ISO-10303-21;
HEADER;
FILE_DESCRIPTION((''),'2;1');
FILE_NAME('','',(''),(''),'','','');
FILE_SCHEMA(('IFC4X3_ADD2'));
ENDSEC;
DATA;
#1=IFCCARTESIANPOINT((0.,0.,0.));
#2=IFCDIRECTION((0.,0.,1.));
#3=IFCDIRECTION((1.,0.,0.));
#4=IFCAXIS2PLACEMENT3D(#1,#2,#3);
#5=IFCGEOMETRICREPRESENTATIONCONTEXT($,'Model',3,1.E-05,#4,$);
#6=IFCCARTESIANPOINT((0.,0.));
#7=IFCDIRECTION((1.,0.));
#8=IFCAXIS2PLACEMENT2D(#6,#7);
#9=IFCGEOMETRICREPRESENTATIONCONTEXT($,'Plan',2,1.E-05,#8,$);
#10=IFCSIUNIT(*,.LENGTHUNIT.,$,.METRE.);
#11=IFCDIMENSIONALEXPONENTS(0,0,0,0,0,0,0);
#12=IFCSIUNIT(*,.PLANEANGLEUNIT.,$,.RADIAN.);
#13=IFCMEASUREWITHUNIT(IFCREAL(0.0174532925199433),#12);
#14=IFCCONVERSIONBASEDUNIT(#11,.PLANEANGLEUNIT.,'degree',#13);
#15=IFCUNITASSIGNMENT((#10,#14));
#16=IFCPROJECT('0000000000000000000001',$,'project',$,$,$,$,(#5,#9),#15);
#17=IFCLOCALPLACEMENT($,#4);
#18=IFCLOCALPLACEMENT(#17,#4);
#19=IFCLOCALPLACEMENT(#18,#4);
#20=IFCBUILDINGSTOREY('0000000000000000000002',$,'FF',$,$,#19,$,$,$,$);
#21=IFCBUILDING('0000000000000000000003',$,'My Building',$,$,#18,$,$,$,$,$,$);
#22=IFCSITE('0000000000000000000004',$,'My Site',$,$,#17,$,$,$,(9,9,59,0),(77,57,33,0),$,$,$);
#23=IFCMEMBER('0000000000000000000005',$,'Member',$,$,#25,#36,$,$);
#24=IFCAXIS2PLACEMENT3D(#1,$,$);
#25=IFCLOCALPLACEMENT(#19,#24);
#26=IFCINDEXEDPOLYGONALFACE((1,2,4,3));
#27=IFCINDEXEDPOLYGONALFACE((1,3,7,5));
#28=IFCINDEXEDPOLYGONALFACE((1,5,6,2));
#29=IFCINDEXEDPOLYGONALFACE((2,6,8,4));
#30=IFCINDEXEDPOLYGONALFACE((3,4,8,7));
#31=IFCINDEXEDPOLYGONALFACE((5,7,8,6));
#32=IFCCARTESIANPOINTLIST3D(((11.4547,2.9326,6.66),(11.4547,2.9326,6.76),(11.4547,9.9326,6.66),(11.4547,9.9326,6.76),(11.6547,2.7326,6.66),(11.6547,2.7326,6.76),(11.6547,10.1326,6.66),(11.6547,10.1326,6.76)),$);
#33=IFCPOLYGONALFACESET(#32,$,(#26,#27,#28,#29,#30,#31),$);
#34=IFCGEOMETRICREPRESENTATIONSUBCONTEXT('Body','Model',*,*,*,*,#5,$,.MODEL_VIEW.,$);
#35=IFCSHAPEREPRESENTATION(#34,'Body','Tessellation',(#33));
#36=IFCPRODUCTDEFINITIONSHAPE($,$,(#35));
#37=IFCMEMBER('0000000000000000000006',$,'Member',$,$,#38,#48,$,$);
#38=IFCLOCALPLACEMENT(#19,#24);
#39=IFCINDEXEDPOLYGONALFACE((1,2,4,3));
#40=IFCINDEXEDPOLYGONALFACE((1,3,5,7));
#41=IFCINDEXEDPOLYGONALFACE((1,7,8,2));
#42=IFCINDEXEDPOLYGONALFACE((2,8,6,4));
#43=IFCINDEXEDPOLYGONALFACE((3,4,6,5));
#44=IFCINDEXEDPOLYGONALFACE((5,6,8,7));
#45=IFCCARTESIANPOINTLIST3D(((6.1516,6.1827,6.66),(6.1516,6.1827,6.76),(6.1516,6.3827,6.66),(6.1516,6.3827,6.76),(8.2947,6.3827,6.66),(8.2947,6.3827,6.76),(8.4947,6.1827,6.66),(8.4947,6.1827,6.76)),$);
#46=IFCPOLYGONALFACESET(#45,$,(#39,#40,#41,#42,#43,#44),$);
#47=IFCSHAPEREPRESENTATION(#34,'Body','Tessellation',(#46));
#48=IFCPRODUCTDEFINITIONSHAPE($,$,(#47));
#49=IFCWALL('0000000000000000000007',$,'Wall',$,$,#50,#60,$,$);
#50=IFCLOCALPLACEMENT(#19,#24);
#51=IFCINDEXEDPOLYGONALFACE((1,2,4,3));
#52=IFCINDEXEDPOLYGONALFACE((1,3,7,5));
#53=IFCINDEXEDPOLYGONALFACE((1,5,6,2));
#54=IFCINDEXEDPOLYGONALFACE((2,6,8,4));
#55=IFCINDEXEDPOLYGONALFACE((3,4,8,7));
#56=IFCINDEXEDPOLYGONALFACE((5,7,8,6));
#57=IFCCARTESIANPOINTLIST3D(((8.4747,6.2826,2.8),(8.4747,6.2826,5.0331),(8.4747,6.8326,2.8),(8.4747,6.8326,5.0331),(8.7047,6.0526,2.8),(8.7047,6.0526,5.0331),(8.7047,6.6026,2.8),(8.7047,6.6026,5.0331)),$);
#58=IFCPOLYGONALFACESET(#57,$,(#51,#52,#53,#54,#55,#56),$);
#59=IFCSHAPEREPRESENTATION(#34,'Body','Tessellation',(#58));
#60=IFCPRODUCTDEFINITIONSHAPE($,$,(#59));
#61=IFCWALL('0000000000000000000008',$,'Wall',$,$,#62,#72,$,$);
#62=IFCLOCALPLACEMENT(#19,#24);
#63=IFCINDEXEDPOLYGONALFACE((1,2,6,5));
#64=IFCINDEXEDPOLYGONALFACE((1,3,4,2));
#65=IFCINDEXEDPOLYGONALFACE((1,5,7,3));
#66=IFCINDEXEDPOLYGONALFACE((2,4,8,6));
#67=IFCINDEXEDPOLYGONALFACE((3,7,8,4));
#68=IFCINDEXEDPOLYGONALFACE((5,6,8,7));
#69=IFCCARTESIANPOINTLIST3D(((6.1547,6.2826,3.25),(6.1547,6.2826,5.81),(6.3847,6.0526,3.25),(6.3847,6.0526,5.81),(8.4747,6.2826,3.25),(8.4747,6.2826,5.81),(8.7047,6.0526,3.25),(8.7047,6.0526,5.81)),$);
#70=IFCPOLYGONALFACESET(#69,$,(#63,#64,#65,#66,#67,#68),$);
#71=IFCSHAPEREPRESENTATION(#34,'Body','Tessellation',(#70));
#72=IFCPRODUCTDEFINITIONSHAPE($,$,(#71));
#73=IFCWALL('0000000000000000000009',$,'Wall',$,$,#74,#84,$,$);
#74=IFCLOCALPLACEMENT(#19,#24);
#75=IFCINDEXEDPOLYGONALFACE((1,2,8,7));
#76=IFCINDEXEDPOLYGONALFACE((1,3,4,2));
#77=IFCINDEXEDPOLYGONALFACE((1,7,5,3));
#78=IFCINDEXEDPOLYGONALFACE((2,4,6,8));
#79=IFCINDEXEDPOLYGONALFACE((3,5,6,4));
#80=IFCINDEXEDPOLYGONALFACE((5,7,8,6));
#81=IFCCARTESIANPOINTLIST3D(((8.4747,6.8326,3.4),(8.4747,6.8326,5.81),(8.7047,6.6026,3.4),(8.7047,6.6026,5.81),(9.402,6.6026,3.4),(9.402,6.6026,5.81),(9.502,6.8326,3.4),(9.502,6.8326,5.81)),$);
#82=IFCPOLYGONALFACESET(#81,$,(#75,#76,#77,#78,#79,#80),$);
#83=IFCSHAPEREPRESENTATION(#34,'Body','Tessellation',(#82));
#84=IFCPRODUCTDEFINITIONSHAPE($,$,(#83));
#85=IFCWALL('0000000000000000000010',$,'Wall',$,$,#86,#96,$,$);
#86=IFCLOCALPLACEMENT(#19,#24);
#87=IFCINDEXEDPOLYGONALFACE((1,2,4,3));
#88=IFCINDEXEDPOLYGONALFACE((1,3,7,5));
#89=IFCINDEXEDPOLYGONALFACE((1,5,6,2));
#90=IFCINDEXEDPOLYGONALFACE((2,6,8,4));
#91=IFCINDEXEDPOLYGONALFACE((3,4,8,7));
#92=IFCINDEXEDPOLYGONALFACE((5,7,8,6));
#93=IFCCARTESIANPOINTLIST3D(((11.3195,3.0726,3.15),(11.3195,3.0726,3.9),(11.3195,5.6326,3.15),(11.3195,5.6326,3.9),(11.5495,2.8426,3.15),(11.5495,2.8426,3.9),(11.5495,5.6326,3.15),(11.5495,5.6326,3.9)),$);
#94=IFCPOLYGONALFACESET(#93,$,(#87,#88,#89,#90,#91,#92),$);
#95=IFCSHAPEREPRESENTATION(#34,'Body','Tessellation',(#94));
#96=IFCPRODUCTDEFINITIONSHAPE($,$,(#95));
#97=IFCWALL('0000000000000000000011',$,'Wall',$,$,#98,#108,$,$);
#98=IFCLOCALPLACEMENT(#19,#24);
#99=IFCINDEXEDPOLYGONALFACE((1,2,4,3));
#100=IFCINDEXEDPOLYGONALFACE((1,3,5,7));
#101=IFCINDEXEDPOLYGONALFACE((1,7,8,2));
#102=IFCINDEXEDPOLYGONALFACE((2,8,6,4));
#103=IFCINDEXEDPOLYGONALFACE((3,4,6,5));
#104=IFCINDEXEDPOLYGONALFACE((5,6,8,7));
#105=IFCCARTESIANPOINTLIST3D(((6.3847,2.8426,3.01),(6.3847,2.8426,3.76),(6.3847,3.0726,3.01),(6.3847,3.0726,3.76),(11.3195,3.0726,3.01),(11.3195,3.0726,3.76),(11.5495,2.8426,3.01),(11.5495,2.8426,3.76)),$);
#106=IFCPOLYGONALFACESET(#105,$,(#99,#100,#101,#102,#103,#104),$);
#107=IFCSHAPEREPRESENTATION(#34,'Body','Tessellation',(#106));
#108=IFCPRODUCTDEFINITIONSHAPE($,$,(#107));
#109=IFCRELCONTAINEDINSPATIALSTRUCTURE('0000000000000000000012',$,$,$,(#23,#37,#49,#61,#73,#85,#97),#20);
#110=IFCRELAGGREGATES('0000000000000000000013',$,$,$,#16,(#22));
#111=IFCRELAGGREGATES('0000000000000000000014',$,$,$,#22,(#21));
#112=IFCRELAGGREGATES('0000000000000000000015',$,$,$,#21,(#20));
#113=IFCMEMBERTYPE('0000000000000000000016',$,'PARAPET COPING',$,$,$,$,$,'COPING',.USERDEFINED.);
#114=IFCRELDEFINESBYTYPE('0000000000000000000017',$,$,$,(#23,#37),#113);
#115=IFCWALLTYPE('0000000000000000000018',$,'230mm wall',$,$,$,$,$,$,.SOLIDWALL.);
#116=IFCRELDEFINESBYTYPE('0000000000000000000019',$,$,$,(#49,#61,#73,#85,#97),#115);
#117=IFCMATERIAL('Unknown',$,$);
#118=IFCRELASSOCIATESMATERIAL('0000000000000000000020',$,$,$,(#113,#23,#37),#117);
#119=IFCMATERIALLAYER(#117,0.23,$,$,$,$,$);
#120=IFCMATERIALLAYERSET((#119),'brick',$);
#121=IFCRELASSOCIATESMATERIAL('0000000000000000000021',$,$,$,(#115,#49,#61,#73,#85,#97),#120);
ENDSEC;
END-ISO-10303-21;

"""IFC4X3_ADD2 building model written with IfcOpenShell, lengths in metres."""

from ifc_helpers import new_model, entity, si_unit, converted_unit, frame, origin_with_axes, origin_2d_with_axis, place, context, subcontext, project, spatial, line, indexed_curve, rectangle, outline, extrude, clip, halfspace, material, layer, layer_set, layer_usage, material_profile, profile_set, profile_usage, type_object, element, save


model = new_model("IFC4X3_ADD2")

# Units and contexts
model_context = context("Model", 3, precision=1e-05, world=origin_with_axes())
plan_context = context("Plan", 2, precision=1e-05, world=origin_2d_with_axis())
body_context_1 = subcontext(model_context, "Body", "Model", "MODEL_VIEW")
ifc_project = project(units=[si_unit("LENGTHUNIT", "METRE"), converted_unit("PLANEANGLEUNIT", "degree", entity("IfcReal", 0.0174532925199433), si_unit("PLANEANGLEUNIT", "RADIAN"), dimensions=[0, 0, 0, 0, 0, 0, 0])], contexts=[model_context, plan_context])

# Site, building, storey
site_placement = place(None, origin_with_axes())
site = spatial("IfcSite", under=ifc_project, at=site_placement, Name="My Site", RefLatitude=(9, 9, 59, 0), RefLongitude=(77, 57, 33, 0))
building_placement = place(site_placement, origin_with_axes())
building = spatial("IfcBuilding", under=site, at=building_placement, Name="My Building")
storey_placement = place(building_placement, origin_with_axes())
storey = spatial("IfcBuildingStorey", under=building, at=storey_placement, Name="FF")

# Members
ifc_material = material(Name="Unknown")
ifc_material_profile = material_profile(ifc_material, rectangle(XDim=0.2, YDim=0.1))
ifc_profile_set = profile_set([ifc_material_profile])
ifc_profile_usage_1 = profile_usage(ifc_profile_set, cardinal=5)
member_type = type_object("IfcMemberType", Name="PARAPET COPING", ElementType="COPING", PredefinedType="USERDEFINED", material=ifc_profile_set)
member_1_placement = place(storey_placement, frame((11.5547, 2.7326, 6.71), z_axis=(0.0, 1.0, 0.0), x_axis=(-1.0, 0.0, 0.0)))
element("IfcMember", 1, at=member_1_placement, inside=storey, type_object=member_type, material=ifc_profile_usage_1, Name="Member", context=body_context_1, shape_type="Clipping", body=[
    clip(clip(extrude(rectangle(XDim=0.2, YDim=0.1), origin_with_axes(), (0.0, 0.0, 1.0), 7.4), halfspace(frame((-0.1, -6.66, 7.4), z_axis=(0.707107, 0.0, 0.707107), x_axis=(0.0, -1.0, 0.0)), False)), halfspace(frame((-0.1, -6.66, 0.0), z_axis=(0.707106, 0.0, -0.707108), x_axis=(0.0, -1.0, 0.0)), False)),
])
ifc_profile_usage_2 = profile_usage(ifc_profile_set, cardinal=5)
member_2_placement = place(storey_placement, frame((8.4947, 6.2827, 6.71), z_axis=(-1.0, 0.0, 0.0), x_axis=(0.0, -1.0, 0.0)))
element("IfcMember", 2, at=member_2_placement, inside=storey, type_object=member_type, material=ifc_profile_usage_2, Name="Member", context=body_context_1, shape_type="Clipping", body=[
    clip(extrude(rectangle(XDim=0.2, YDim=0.1), origin_with_axes(), (0.0, 0.0, 1.0), 2.3431), halfspace(frame((0.1, -6.66, 0.0), z_axis=(-0.707108, 0.0, -0.707105), x_axis=(0.0, 1.0, 0.0)), False)),
])

# Shared definitions
ifc_layer_1 = layer(ifc_material, 0.23)
ifc_layer_set_1 = layer_set([ifc_layer_1], Name="brick")
wall_type_1 = type_object("IfcWallType", Name="230mm wall", PredefinedType="SOLIDWALL", material=ifc_layer_set_1)

# Walls
ifc_layer_usage_1 = layer_usage(ifc_layer_set_1, "AXIS2", "POSITIVE", 0.0)
wall_1_placement = place(storey_placement, frame((8.7047, 6.2826, 2.8), z_axis=(0.0, 0.0, 1.0), x_axis=(0.0, 1.0, 0.0)))
element("IfcWall", 3, at=wall_1_placement, inside=storey, type_object=wall_type_1, material=ifc_layer_usage_1, Name="Wall", context=body_context_1, shape_type="SweptSolid", body=[
    extrude(outline(indexed_curve([(-0.23, 0.0), (0.0, 0.23), (0.55, 0.23), (0.32, 0.0)], segments=[line(1, 2, 3, 4, 1)])), origin_with_axes(), (0.0, 0.0, 1.0), 2.2331),
])
ifc_layer_usage_2 = layer_usage(ifc_layer_set_1, "AXIS2", "POSITIVE", 0.0)
wall_2_placement = place(storey_placement, frame((8.7047, 6.2826, 3.25), z_axis=(0.0, 0.0, 1.0), x_axis=(-1.0, 0.0, 0.0)))
element("IfcWall", 4, at=wall_2_placement, inside=storey, type_object=wall_type_1, material=ifc_layer_usage_2, Name="Wall", context=body_context_1, shape_type="SweptSolid", body=[
    extrude(outline(indexed_curve([(0.23, 0.0), (0.0, 0.23), (2.32, 0.23), (2.55, 0.0)], segments=[line(1, 2, 3, 4, 1)])), origin_with_axes(), (0.0, 0.0, 1.0), 2.56),
])
ifc_layer_usage_3 = layer_usage(ifc_layer_set_1, "AXIS2", "POSITIVE", 0.0)
wall_3_placement = place(storey_placement, frame((9.502, 6.8326, 3.4), z_axis=(0.0, 0.0, 1.0), x_axis=(-1.0, 0.0, 0.0)))
element("IfcWall", 5, at=wall_3_placement, inside=storey, type_object=wall_type_1, material=ifc_layer_usage_3, Name="Wall", context=body_context_1, shape_type="SweptSolid", body=[
    extrude(outline(indexed_curve([(0.0, 0.0), (0.1, 0.23), (0.7974, 0.23), (1.0274, 0.0)], segments=[line(1, 2, 3, 4, 1)])), origin_with_axes(), (0.0, 0.0, 1.0), 2.41),
])
ifc_layer_usage_4 = layer_usage(ifc_layer_set_1, "AXIS2", "POSITIVE", 0.0)
wall_4_placement = place(storey_placement, frame((11.5495, 2.8426, 3.15), z_axis=(0.0, 0.0, 1.0), x_axis=(0.0, 1.0, 0.0)))
element("IfcWall", 6, at=wall_4_placement, inside=storey, type_object=wall_type_1, material=ifc_layer_usage_4, Name="Wall", context=body_context_1, shape_type="SweptSolid", body=[
    extrude(outline(indexed_curve([(0.0, 0.0), (0.23, 0.23), (2.79, 0.23), (2.79, 0.0)], segments=[line(1, 2, 3, 4, 1)])), origin_with_axes(), (0.0, 0.0, 1.0), 0.75),
])
ifc_layer_usage_5 = layer_usage(ifc_layer_set_1, "AXIS2", "POSITIVE", 0.0)
wall_5_placement = place(storey_placement, frame((6.3847, 2.8426, 3.01), z_axis=(0.0, 0.0, 1.0), x_axis=(1.0, 0.0, 0.0)))
element("IfcWall", 7, at=wall_5_placement, inside=storey, type_object=wall_type_1, material=ifc_layer_usage_5, Name="Wall", context=body_context_1, shape_type="SweptSolid", body=[
    extrude(outline(indexed_curve([(0.0, 0.0), (0.0, 0.23), (4.9349, 0.23), (5.1649, 0.0)], segments=[line(1, 2, 3, 4, 1)])), origin_with_axes(), (0.0, 0.0, 1.0), 0.75),
])

save(model, "model.ifc")
